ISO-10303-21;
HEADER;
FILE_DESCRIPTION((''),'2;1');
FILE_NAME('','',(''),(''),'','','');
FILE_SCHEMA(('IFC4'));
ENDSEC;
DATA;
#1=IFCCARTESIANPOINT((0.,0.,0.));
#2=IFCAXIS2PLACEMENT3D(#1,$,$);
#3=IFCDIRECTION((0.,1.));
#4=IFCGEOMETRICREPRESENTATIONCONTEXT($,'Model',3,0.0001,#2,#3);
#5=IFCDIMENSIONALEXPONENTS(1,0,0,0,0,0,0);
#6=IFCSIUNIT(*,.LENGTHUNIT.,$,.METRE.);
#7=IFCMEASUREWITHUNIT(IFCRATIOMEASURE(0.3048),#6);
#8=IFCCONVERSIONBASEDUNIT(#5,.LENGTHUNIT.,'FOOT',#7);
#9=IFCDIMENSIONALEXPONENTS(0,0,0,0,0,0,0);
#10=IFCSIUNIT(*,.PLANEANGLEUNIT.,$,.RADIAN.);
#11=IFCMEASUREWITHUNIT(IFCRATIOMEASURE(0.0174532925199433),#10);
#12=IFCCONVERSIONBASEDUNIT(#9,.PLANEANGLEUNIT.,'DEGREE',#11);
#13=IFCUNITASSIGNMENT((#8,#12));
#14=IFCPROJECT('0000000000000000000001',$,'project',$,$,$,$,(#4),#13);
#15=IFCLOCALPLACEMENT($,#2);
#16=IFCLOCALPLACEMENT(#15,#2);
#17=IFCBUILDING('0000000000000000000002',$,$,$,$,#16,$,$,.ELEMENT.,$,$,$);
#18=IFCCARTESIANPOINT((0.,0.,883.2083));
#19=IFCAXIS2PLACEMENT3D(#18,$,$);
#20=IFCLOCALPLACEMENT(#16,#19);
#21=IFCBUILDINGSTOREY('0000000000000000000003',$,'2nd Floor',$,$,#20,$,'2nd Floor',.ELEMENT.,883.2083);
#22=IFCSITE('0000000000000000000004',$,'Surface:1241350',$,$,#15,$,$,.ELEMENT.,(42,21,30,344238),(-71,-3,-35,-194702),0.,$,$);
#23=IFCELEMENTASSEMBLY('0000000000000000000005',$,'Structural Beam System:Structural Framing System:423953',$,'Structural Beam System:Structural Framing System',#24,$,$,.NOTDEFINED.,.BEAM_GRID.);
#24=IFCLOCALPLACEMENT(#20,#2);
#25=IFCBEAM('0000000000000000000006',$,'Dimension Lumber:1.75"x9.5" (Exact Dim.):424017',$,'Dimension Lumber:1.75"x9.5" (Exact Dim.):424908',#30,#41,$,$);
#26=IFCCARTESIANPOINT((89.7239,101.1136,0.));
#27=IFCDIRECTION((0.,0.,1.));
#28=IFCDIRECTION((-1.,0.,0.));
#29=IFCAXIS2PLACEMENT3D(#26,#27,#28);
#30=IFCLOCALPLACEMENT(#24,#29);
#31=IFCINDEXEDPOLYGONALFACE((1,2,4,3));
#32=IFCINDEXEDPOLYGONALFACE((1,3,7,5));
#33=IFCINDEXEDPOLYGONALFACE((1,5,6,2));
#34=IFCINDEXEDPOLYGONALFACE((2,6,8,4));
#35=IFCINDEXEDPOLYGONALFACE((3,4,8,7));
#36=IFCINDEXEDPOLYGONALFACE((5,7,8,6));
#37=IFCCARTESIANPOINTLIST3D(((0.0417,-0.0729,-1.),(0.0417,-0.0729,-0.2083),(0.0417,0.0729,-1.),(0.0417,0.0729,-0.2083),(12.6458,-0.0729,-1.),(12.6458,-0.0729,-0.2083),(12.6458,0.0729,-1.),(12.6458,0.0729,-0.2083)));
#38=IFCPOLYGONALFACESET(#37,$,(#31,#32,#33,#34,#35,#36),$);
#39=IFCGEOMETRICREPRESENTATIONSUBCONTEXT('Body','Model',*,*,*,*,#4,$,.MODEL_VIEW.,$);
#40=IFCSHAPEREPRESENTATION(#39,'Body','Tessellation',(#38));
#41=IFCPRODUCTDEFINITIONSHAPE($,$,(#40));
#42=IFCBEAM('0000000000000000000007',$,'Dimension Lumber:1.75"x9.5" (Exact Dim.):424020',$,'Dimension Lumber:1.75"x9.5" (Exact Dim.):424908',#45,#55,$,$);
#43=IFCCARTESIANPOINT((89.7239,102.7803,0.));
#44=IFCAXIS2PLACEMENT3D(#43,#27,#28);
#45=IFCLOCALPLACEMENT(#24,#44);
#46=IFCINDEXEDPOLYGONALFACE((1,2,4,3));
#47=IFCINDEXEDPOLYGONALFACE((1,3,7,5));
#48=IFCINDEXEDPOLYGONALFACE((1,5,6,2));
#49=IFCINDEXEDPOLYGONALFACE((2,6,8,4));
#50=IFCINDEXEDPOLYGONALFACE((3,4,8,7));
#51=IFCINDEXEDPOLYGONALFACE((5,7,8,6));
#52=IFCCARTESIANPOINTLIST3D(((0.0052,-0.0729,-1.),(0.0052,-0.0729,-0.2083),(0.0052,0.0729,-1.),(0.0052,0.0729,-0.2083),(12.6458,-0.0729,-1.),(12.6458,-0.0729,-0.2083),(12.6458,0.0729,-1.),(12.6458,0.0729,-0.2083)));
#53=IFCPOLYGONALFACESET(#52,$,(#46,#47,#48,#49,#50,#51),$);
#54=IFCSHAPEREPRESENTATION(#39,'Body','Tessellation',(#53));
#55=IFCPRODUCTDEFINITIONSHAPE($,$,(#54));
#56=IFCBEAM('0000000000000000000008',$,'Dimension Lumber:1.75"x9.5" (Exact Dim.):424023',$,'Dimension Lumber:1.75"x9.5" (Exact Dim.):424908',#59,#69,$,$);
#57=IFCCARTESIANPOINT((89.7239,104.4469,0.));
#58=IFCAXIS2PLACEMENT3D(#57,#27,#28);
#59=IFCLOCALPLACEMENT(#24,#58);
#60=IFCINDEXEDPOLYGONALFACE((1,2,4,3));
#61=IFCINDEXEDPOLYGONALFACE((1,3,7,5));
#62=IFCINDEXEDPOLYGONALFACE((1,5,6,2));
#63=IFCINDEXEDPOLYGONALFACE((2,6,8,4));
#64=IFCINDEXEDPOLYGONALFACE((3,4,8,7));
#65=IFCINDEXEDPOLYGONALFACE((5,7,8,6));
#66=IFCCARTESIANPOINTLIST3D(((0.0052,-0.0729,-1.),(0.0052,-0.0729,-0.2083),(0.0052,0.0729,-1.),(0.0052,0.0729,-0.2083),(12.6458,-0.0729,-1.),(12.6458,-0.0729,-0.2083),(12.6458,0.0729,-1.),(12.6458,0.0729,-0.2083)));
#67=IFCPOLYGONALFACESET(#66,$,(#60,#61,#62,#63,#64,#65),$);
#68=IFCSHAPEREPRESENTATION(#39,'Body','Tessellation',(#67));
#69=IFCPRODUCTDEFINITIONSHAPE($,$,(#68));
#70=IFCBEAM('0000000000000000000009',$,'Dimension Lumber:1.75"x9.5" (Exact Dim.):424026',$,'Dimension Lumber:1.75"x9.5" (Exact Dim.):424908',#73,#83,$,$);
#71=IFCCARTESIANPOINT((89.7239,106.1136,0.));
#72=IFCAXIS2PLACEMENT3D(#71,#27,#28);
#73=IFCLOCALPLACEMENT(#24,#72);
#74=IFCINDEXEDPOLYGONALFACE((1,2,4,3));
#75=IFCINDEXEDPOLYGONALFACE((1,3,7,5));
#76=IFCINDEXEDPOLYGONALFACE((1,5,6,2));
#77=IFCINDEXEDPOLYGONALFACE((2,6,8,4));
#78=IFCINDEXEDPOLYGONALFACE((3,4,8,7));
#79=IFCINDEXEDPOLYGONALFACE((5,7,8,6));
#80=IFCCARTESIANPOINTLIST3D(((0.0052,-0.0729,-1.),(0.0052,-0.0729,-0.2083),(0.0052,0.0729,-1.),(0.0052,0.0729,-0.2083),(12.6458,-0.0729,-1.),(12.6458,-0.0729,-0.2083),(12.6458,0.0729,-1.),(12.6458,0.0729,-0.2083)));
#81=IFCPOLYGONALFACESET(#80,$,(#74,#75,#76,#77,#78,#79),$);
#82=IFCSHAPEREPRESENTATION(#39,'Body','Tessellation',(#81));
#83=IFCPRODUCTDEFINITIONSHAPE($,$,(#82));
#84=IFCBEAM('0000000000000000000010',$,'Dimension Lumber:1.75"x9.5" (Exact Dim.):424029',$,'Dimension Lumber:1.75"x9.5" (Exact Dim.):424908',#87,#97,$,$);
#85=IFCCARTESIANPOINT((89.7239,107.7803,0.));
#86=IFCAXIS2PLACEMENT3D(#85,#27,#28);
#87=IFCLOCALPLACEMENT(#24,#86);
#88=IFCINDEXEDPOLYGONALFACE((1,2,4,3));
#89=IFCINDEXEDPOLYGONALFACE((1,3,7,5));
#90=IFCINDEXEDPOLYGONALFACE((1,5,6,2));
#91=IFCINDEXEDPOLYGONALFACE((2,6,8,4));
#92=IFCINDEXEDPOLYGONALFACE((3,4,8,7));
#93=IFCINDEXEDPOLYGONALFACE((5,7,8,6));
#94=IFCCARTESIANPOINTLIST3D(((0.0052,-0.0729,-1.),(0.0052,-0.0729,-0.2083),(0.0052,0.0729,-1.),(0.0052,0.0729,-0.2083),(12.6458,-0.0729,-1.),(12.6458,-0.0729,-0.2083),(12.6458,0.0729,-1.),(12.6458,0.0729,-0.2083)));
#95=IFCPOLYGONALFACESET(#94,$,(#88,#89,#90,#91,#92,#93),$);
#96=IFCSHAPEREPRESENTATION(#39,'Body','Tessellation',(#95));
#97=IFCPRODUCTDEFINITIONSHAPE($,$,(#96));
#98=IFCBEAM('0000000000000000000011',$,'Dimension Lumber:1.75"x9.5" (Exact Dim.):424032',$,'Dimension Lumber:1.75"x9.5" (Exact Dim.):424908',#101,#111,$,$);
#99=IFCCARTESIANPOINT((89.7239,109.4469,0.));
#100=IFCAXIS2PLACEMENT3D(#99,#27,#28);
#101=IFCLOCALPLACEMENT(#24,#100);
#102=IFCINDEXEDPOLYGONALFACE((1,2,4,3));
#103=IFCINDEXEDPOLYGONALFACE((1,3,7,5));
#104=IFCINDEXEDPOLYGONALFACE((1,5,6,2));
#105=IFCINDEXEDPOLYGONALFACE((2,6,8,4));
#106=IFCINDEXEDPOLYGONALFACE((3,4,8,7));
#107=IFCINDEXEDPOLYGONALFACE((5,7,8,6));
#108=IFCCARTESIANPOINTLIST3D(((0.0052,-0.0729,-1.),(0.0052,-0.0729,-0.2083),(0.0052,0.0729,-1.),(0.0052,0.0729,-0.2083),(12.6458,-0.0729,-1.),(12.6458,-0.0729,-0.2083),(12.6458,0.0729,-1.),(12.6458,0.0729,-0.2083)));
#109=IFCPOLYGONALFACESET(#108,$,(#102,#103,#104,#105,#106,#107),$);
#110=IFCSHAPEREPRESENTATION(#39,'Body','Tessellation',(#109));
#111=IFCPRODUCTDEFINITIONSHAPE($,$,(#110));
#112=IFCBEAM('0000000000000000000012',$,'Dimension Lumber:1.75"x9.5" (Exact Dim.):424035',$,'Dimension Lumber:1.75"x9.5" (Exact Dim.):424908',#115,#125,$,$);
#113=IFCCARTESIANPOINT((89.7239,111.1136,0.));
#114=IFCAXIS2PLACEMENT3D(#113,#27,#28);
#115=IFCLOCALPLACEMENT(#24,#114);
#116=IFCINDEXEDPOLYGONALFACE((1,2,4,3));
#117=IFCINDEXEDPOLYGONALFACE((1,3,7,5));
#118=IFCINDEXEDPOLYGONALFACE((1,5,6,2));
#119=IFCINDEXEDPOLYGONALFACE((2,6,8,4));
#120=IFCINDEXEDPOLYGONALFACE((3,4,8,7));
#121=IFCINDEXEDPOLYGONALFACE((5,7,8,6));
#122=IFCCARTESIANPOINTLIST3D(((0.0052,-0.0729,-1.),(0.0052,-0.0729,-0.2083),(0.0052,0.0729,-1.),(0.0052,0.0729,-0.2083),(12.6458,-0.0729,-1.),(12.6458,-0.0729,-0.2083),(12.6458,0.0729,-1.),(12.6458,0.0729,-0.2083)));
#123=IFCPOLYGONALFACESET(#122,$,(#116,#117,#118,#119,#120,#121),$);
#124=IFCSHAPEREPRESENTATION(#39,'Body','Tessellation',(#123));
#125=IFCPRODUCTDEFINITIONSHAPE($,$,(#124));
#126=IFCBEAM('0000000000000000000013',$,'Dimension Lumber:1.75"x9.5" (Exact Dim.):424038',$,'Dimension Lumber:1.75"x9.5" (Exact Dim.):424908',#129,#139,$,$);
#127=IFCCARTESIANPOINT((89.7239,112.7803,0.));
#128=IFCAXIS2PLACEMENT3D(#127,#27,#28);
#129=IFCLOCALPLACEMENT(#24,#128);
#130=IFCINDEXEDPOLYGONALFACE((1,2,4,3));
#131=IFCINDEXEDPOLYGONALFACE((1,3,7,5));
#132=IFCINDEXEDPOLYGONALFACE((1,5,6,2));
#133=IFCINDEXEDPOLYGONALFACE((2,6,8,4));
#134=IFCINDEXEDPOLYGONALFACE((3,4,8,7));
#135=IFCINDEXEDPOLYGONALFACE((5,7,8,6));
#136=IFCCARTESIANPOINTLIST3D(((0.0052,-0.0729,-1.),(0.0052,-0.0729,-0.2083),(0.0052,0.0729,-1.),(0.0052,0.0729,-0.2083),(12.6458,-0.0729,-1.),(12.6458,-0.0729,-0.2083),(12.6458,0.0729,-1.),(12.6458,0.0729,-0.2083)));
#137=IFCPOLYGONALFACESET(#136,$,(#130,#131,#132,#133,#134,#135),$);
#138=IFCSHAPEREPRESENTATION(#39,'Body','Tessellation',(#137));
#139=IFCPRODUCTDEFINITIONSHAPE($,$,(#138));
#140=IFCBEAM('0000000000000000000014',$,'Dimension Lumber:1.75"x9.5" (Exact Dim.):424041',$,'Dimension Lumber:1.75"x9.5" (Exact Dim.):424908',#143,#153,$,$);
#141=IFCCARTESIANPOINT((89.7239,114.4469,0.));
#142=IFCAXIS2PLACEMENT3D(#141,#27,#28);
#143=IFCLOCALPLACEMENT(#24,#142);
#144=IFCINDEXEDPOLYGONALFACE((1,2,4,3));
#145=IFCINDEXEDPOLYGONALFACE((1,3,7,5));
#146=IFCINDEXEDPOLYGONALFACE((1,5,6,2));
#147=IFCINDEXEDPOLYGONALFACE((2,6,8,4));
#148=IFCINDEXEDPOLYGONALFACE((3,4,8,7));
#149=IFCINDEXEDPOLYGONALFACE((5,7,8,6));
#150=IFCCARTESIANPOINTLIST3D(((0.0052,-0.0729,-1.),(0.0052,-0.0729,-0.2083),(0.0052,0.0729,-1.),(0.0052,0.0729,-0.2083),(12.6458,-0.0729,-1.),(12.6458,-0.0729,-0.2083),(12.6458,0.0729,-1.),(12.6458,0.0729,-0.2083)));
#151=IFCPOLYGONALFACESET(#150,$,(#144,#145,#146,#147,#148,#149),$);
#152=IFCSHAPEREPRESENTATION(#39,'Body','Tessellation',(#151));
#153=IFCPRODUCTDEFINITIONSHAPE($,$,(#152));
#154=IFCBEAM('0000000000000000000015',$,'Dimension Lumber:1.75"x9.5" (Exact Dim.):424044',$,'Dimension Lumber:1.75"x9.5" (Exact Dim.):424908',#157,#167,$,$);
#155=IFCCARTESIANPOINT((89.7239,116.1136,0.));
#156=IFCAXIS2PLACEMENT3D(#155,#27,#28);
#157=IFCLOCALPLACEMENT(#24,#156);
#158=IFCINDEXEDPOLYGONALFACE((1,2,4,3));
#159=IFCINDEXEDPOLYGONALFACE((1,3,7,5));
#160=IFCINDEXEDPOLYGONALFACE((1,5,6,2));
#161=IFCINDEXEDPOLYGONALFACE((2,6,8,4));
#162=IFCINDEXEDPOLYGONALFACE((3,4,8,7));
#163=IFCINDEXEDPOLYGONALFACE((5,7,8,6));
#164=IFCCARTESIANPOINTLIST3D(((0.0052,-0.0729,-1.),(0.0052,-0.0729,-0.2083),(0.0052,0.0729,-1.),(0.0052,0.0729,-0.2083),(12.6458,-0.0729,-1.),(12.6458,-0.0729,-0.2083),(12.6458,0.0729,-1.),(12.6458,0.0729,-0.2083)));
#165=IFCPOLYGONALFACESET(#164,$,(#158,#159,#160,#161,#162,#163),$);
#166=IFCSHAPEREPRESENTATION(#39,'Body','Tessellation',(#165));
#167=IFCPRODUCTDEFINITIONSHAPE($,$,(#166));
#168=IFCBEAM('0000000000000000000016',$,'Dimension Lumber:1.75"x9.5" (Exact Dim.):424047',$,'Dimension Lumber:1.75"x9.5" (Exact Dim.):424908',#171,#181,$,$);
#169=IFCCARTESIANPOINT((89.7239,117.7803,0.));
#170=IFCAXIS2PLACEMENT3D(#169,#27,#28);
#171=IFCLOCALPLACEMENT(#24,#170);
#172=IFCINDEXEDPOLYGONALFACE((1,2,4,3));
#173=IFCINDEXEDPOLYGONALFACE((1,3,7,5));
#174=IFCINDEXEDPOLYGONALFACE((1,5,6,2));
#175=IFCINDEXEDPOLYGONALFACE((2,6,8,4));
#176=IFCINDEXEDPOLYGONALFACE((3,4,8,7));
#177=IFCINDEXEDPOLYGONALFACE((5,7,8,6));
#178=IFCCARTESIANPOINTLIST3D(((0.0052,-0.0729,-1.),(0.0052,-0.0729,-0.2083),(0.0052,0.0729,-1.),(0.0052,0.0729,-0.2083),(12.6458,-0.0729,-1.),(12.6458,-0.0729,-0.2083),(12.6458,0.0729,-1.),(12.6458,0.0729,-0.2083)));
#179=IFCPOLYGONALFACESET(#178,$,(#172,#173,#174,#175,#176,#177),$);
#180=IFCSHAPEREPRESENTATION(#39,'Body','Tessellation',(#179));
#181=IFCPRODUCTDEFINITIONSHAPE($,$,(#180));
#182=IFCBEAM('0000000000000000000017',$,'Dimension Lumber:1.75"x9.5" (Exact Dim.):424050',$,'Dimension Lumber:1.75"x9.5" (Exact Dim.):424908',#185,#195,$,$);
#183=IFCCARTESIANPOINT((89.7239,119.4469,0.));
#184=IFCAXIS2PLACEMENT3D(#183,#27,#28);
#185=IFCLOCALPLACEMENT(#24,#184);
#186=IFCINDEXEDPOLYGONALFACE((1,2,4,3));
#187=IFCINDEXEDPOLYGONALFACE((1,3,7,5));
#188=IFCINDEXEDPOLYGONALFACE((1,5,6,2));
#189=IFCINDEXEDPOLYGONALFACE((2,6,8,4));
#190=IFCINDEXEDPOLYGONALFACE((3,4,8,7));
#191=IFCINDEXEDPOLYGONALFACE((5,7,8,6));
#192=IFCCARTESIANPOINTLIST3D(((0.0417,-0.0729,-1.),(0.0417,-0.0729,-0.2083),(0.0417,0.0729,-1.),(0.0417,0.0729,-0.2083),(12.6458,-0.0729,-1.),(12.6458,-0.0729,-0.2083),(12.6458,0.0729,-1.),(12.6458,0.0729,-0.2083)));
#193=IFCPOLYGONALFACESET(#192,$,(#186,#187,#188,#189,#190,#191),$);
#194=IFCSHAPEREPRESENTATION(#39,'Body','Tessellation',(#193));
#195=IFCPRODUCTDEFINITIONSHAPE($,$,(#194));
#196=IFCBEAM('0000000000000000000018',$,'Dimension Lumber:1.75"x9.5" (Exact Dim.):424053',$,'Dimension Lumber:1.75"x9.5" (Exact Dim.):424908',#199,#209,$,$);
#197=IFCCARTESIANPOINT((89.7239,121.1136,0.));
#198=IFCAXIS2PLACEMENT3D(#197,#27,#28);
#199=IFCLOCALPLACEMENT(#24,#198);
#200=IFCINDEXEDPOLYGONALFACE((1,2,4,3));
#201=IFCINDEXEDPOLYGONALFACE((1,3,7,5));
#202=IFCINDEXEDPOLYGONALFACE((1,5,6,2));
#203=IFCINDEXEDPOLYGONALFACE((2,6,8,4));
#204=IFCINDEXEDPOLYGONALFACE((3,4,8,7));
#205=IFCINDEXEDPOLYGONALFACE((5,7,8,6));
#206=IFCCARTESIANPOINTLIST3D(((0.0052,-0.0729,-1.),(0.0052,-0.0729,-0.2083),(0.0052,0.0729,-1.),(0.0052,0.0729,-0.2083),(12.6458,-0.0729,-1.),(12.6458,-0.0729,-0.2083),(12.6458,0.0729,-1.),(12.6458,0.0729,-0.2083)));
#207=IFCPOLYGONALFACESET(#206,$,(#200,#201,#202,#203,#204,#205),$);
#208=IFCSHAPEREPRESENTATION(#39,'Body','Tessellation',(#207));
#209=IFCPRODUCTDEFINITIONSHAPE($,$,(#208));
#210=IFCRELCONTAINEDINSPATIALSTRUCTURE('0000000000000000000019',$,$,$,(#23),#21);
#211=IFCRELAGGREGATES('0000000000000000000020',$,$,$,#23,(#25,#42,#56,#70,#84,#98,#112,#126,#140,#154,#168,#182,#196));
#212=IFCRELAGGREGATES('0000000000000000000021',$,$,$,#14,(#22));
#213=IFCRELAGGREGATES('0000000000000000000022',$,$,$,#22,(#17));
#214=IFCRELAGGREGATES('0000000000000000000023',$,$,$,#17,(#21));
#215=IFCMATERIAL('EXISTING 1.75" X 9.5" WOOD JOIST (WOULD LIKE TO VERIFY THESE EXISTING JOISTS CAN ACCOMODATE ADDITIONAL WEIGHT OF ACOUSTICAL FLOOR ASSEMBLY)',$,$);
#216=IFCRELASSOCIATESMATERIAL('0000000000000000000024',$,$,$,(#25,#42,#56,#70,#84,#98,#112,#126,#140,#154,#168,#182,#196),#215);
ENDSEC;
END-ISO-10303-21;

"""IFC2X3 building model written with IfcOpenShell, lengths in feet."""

from ifc_helpers import new_model, entity, si_unit, converted_unit, direction, frame, frame_2d, origin, origin_2d_with_axis, place, context, subcontext, project, spatial, rectangle, extrude, material, element, aggregate, save


model = new_model("IFC2X3")

# Units and contexts
model_context = context("Model", 3, precision=0.0001, world=origin(), true_north=direction((0.0, 1.0)))
body_context = subcontext(model_context, "Body", "Model", "MODEL_VIEW")
ifc_project = project(units=[converted_unit("LENGTHUNIT", "FOOT", entity("IfcRatioMeasure", 0.3048), si_unit("LENGTHUNIT", "METRE"), dimensions=[1, 0, 0, 0, 0, 0, 0]), converted_unit("PLANEANGLEUNIT", "DEGREE", entity("IfcRatioMeasure", 0.0174532925199433), si_unit("PLANEANGLEUNIT", "RADIAN"), dimensions=[0, 0, 0, 0, 0, 0, 0])], contexts=[model_context])

# Site, building, storey
site_placement = place(None, origin())
site = spatial("IfcSite", under=ifc_project, at=site_placement, Name="Surface:1241350", CompositionType="ELEMENT", RefLatitude=(42, 21, 30, 344238), RefLongitude=(-71, -3, -35, -194702), RefElevation=0.0)
building_placement = place(site_placement, origin())
building = spatial("IfcBuilding", under=site, at=building_placement, CompositionType="ELEMENT")
storey_placement = place(building_placement, frame((0.0, 0.0, 883.2083)))
storey = spatial("IfcBuildingStorey", under=building, at=storey_placement, Name="2nd Floor", LongName="2nd Floor", CompositionType="ELEMENT", Elevation=883.2083)

# Element assembly, beams
assembly_placement = place(storey_placement, origin())
assembly = element("IfcElementAssembly", 1, at=assembly_placement, inside=storey, Name="Structural Beam System:Structural Framing System:423953", ObjectType="Structural Beam System:Structural Framing System", AssemblyPlace="NOTDEFINED", PredefinedType="BEAM_GRID")
ifc_material_1 = material(Name="EXISTING 1.75\" X 9.5\" WOOD JOIST (WOULD LIKE TO VERIFY THESE EXISTING JOISTS CAN ACCOMODATE ADDITIONAL WEIGHT OF ACOUSTICAL FLOOR ASSEMBLY)")
beam_1_placement = place(assembly_placement, frame((89.7239, 101.1136, 0.0), z_axis=(0.0, 0.0, 1.0), x_axis=(-1.0, 0.0, 0.0)))
beam_1 = element("IfcBeam", 2, at=beam_1_placement, material=ifc_material_1, Name="Dimension Lumber:1.75\"x9.5\" (Exact Dim.):424017", ObjectType="Dimension Lumber:1.75\"x9.5\" (Exact Dim.):424908", context=body_context, shape_type="SweptSolid", body=[
    extrude(rectangle(XDim=0.7917, YDim=0.1458, at=origin_2d_with_axis()), frame((0.0417, 0.0, -0.6042), z_axis=(1.0, 0.0, 0.0), x_axis=(0.0, 0.0, -1.0)), (0.0, 0.0, 1.0), 12.6042),
])
beam_2_placement = place(assembly_placement, frame((89.7239, 102.7803, 0.0), z_axis=(0.0, 0.0, 1.0), x_axis=(-1.0, 0.0, 0.0)))
beam_2 = element("IfcBeam", 3, at=beam_2_placement, material=ifc_material_1, Name="Dimension Lumber:1.75\"x9.5\" (Exact Dim.):424020", ObjectType="Dimension Lumber:1.75\"x9.5\" (Exact Dim.):424908", context=body_context, shape_type="SweptSolid", body=[
    extrude(rectangle(XDim=0.7917, YDim=0.1458, at=origin_2d_with_axis()), frame((0.0052, 0.0, -0.6042), z_axis=(1.0, 0.0, 0.0), x_axis=(0.0, 0.0, -1.0)), (0.0, 0.0, 1.0), 12.6406),
])
beam_3_placement = place(assembly_placement, frame((89.7239, 104.4469, 0.0), z_axis=(0.0, 0.0, 1.0), x_axis=(-1.0, 0.0, 0.0)))
beam_3 = element("IfcBeam", 4, at=beam_3_placement, material=ifc_material_1, Name="Dimension Lumber:1.75\"x9.5\" (Exact Dim.):424023", ObjectType="Dimension Lumber:1.75\"x9.5\" (Exact Dim.):424908", context=body_context, shape_type="SweptSolid", body=[
    extrude(rectangle(XDim=0.7917, YDim=0.1458, at=origin_2d_with_axis()), frame((0.0052, 0.0, -0.6042), z_axis=(1.0, 0.0, 0.0), x_axis=(0.0, 0.0, -1.0)), (0.0, 0.0, 1.0), 12.6406),
])
beam_4_placement = place(assembly_placement, frame((89.7239, 106.1136, 0.0), z_axis=(0.0, 0.0, 1.0), x_axis=(-1.0, 0.0, 0.0)))
beam_4 = element("IfcBeam", 5, at=beam_4_placement, material=ifc_material_1, Name="Dimension Lumber:1.75\"x9.5\" (Exact Dim.):424026", ObjectType="Dimension Lumber:1.75\"x9.5\" (Exact Dim.):424908", context=body_context, shape_type="SweptSolid", body=[
    extrude(rectangle(XDim=0.7917, YDim=0.1458, at=origin_2d_with_axis()), frame((0.0052, 0.0, -0.6042), z_axis=(1.0, 0.0, 0.0), x_axis=(0.0, 0.0, -1.0)), (0.0, 0.0, 1.0), 12.6406),
])
beam_5_placement = place(assembly_placement, frame((89.7239, 107.7803, 0.0), z_axis=(0.0, 0.0, 1.0), x_axis=(-1.0, 0.0, 0.0)))
beam_5 = element("IfcBeam", 6, at=beam_5_placement, material=ifc_material_1, Name="Dimension Lumber:1.75\"x9.5\" (Exact Dim.):424029", ObjectType="Dimension Lumber:1.75\"x9.5\" (Exact Dim.):424908", context=body_context, shape_type="SweptSolid", body=[
    extrude(rectangle(XDim=0.7917, YDim=0.1458, at=origin_2d_with_axis()), frame((0.0052, 0.0, -0.6042), z_axis=(1.0, 0.0, 0.0), x_axis=(0.0, 0.0, -1.0)), (0.0, 0.0, 1.0), 12.6406),
])
beam_6_placement = place(assembly_placement, frame((89.7239, 109.4469, 0.0), z_axis=(0.0, 0.0, 1.0), x_axis=(-1.0, 0.0, 0.0)))
beam_6 = element("IfcBeam", 7, at=beam_6_placement, material=ifc_material_1, Name="Dimension Lumber:1.75\"x9.5\" (Exact Dim.):424032", ObjectType="Dimension Lumber:1.75\"x9.5\" (Exact Dim.):424908", context=body_context, shape_type="SweptSolid", body=[
    extrude(rectangle(XDim=0.7917, YDim=0.1458, at=frame_2d((0.0, 0.0), x_axis=(1.0, 0.0))), frame((0.0052, 0.0, -0.6042), z_axis=(1.0, 0.0, 0.0), x_axis=(0.0, 0.0, -1.0)), (0.0, 0.0, 1.0), 12.6406),
])
beam_7_placement = place(assembly_placement, frame((89.7239, 111.1136, 0.0), z_axis=(0.0, 0.0, 1.0), x_axis=(-1.0, 0.0, 0.0)))
beam_7 = element("IfcBeam", 8, at=beam_7_placement, material=ifc_material_1, Name="Dimension Lumber:1.75\"x9.5\" (Exact Dim.):424035", ObjectType="Dimension Lumber:1.75\"x9.5\" (Exact Dim.):424908", context=body_context, shape_type="SweptSolid", body=[
    extrude(rectangle(XDim=0.7917, YDim=0.1458, at=origin_2d_with_axis()), frame((0.0052, 0.0, -0.6042), z_axis=(1.0, 0.0, 0.0), x_axis=(0.0, 0.0, -1.0)), (0.0, 0.0, 1.0), 12.6406),
])
beam_8_placement = place(assembly_placement, frame((89.7239, 112.7803, 0.0), z_axis=(0.0, 0.0, 1.0), x_axis=(-1.0, 0.0, 0.0)))
beam_8 = element("IfcBeam", 9, at=beam_8_placement, material=ifc_material_1, Name="Dimension Lumber:1.75\"x9.5\" (Exact Dim.):424038", ObjectType="Dimension Lumber:1.75\"x9.5\" (Exact Dim.):424908", context=body_context, shape_type="SweptSolid", body=[
    extrude(rectangle(XDim=0.7917, YDim=0.1458, at=origin_2d_with_axis()), frame((0.0052, 0.0, -0.6042), z_axis=(1.0, 0.0, 0.0), x_axis=(0.0, 0.0, -1.0)), (0.0, 0.0, 1.0), 12.6406),
])
beam_9_placement = place(assembly_placement, frame((89.7239, 114.4469, 0.0), z_axis=(0.0, 0.0, 1.0), x_axis=(-1.0, 0.0, 0.0)))
beam_9 = element("IfcBeam", 10, at=beam_9_placement, material=ifc_material_1, Name="Dimension Lumber:1.75\"x9.5\" (Exact Dim.):424041", ObjectType="Dimension Lumber:1.75\"x9.5\" (Exact Dim.):424908", context=body_context, shape_type="SweptSolid", body=[
    extrude(rectangle(XDim=0.7917, YDim=0.1458, at=frame_2d((0.0, 0.0), x_axis=(1.0, 0.0))), frame((0.0052, 0.0, -0.6042), z_axis=(1.0, 0.0, 0.0), x_axis=(0.0, 0.0, -1.0)), (0.0, 0.0, 1.0), 12.6406),
])
beam_10_placement = place(assembly_placement, frame((89.7239, 116.1136, 0.0), z_axis=(0.0, 0.0, 1.0), x_axis=(-1.0, 0.0, 0.0)))
beam_10 = element("IfcBeam", 11, at=beam_10_placement, material=ifc_material_1, Name="Dimension Lumber:1.75\"x9.5\" (Exact Dim.):424044", ObjectType="Dimension Lumber:1.75\"x9.5\" (Exact Dim.):424908", context=body_context, shape_type="SweptSolid", body=[
    extrude(rectangle(XDim=0.7917, YDim=0.1458, at=origin_2d_with_axis()), frame((0.0052, 0.0, -0.6042), z_axis=(1.0, 0.0, 0.0), x_axis=(0.0, 0.0, -1.0)), (0.0, 0.0, 1.0), 12.6406),
])
beam_11_placement = place(assembly_placement, frame((89.7239, 117.7803, 0.0), z_axis=(0.0, 0.0, 1.0), x_axis=(-1.0, 0.0, 0.0)))
beam_11 = element("IfcBeam", 12, at=beam_11_placement, material=ifc_material_1, Name="Dimension Lumber:1.75\"x9.5\" (Exact Dim.):424047", ObjectType="Dimension Lumber:1.75\"x9.5\" (Exact Dim.):424908", context=body_context, shape_type="SweptSolid", body=[
    extrude(rectangle(XDim=0.7917, YDim=0.1458, at=origin_2d_with_axis()), frame((0.0052, 0.0, -0.6042), z_axis=(1.0, 0.0, 0.0), x_axis=(0.0, 0.0, -1.0)), (0.0, 0.0, 1.0), 12.6406),
])
beam_12_placement = place(assembly_placement, frame((89.7239, 119.4469, 0.0), z_axis=(0.0, 0.0, 1.0), x_axis=(-1.0, 0.0, 0.0)))
beam_12 = element("IfcBeam", 13, at=beam_12_placement, material=ifc_material_1, Name="Dimension Lumber:1.75\"x9.5\" (Exact Dim.):424050", ObjectType="Dimension Lumber:1.75\"x9.5\" (Exact Dim.):424908", context=body_context, shape_type="SweptSolid", body=[
    extrude(rectangle(XDim=0.7917, YDim=0.1458, at=frame_2d((0.0, 0.0), x_axis=(1.0, 0.0))), frame((0.0417, 0.0, -0.6042), z_axis=(1.0, 0.0, 0.0), x_axis=(0.0, 0.0, -1.0)), (0.0, 0.0, 1.0), 12.6042),
])
beam_13_placement = place(assembly_placement, frame((89.7239, 121.1136, 0.0), z_axis=(0.0, 0.0, 1.0), x_axis=(-1.0, 0.0, 0.0)))
beam_13 = element("IfcBeam", 14, at=beam_13_placement, material=ifc_material_1, Name="Dimension Lumber:1.75\"x9.5\" (Exact Dim.):424053", ObjectType="Dimension Lumber:1.75\"x9.5\" (Exact Dim.):424908", context=body_context, shape_type="SweptSolid", body=[
    extrude(rectangle(XDim=0.7917, YDim=0.1458, at=origin_2d_with_axis()), frame((0.0052, 0.0, -0.6042), z_axis=(1.0, 0.0, 0.0), x_axis=(0.0, 0.0, -1.0)), (0.0, 0.0, 1.0), 12.6406),
])
aggregate(assembly, [beam_1, beam_2, beam_3, beam_4, beam_5, beam_6, beam_7, beam_8, beam_9, beam_10, beam_11, beam_12, beam_13])

save(model, "model.ifc")
